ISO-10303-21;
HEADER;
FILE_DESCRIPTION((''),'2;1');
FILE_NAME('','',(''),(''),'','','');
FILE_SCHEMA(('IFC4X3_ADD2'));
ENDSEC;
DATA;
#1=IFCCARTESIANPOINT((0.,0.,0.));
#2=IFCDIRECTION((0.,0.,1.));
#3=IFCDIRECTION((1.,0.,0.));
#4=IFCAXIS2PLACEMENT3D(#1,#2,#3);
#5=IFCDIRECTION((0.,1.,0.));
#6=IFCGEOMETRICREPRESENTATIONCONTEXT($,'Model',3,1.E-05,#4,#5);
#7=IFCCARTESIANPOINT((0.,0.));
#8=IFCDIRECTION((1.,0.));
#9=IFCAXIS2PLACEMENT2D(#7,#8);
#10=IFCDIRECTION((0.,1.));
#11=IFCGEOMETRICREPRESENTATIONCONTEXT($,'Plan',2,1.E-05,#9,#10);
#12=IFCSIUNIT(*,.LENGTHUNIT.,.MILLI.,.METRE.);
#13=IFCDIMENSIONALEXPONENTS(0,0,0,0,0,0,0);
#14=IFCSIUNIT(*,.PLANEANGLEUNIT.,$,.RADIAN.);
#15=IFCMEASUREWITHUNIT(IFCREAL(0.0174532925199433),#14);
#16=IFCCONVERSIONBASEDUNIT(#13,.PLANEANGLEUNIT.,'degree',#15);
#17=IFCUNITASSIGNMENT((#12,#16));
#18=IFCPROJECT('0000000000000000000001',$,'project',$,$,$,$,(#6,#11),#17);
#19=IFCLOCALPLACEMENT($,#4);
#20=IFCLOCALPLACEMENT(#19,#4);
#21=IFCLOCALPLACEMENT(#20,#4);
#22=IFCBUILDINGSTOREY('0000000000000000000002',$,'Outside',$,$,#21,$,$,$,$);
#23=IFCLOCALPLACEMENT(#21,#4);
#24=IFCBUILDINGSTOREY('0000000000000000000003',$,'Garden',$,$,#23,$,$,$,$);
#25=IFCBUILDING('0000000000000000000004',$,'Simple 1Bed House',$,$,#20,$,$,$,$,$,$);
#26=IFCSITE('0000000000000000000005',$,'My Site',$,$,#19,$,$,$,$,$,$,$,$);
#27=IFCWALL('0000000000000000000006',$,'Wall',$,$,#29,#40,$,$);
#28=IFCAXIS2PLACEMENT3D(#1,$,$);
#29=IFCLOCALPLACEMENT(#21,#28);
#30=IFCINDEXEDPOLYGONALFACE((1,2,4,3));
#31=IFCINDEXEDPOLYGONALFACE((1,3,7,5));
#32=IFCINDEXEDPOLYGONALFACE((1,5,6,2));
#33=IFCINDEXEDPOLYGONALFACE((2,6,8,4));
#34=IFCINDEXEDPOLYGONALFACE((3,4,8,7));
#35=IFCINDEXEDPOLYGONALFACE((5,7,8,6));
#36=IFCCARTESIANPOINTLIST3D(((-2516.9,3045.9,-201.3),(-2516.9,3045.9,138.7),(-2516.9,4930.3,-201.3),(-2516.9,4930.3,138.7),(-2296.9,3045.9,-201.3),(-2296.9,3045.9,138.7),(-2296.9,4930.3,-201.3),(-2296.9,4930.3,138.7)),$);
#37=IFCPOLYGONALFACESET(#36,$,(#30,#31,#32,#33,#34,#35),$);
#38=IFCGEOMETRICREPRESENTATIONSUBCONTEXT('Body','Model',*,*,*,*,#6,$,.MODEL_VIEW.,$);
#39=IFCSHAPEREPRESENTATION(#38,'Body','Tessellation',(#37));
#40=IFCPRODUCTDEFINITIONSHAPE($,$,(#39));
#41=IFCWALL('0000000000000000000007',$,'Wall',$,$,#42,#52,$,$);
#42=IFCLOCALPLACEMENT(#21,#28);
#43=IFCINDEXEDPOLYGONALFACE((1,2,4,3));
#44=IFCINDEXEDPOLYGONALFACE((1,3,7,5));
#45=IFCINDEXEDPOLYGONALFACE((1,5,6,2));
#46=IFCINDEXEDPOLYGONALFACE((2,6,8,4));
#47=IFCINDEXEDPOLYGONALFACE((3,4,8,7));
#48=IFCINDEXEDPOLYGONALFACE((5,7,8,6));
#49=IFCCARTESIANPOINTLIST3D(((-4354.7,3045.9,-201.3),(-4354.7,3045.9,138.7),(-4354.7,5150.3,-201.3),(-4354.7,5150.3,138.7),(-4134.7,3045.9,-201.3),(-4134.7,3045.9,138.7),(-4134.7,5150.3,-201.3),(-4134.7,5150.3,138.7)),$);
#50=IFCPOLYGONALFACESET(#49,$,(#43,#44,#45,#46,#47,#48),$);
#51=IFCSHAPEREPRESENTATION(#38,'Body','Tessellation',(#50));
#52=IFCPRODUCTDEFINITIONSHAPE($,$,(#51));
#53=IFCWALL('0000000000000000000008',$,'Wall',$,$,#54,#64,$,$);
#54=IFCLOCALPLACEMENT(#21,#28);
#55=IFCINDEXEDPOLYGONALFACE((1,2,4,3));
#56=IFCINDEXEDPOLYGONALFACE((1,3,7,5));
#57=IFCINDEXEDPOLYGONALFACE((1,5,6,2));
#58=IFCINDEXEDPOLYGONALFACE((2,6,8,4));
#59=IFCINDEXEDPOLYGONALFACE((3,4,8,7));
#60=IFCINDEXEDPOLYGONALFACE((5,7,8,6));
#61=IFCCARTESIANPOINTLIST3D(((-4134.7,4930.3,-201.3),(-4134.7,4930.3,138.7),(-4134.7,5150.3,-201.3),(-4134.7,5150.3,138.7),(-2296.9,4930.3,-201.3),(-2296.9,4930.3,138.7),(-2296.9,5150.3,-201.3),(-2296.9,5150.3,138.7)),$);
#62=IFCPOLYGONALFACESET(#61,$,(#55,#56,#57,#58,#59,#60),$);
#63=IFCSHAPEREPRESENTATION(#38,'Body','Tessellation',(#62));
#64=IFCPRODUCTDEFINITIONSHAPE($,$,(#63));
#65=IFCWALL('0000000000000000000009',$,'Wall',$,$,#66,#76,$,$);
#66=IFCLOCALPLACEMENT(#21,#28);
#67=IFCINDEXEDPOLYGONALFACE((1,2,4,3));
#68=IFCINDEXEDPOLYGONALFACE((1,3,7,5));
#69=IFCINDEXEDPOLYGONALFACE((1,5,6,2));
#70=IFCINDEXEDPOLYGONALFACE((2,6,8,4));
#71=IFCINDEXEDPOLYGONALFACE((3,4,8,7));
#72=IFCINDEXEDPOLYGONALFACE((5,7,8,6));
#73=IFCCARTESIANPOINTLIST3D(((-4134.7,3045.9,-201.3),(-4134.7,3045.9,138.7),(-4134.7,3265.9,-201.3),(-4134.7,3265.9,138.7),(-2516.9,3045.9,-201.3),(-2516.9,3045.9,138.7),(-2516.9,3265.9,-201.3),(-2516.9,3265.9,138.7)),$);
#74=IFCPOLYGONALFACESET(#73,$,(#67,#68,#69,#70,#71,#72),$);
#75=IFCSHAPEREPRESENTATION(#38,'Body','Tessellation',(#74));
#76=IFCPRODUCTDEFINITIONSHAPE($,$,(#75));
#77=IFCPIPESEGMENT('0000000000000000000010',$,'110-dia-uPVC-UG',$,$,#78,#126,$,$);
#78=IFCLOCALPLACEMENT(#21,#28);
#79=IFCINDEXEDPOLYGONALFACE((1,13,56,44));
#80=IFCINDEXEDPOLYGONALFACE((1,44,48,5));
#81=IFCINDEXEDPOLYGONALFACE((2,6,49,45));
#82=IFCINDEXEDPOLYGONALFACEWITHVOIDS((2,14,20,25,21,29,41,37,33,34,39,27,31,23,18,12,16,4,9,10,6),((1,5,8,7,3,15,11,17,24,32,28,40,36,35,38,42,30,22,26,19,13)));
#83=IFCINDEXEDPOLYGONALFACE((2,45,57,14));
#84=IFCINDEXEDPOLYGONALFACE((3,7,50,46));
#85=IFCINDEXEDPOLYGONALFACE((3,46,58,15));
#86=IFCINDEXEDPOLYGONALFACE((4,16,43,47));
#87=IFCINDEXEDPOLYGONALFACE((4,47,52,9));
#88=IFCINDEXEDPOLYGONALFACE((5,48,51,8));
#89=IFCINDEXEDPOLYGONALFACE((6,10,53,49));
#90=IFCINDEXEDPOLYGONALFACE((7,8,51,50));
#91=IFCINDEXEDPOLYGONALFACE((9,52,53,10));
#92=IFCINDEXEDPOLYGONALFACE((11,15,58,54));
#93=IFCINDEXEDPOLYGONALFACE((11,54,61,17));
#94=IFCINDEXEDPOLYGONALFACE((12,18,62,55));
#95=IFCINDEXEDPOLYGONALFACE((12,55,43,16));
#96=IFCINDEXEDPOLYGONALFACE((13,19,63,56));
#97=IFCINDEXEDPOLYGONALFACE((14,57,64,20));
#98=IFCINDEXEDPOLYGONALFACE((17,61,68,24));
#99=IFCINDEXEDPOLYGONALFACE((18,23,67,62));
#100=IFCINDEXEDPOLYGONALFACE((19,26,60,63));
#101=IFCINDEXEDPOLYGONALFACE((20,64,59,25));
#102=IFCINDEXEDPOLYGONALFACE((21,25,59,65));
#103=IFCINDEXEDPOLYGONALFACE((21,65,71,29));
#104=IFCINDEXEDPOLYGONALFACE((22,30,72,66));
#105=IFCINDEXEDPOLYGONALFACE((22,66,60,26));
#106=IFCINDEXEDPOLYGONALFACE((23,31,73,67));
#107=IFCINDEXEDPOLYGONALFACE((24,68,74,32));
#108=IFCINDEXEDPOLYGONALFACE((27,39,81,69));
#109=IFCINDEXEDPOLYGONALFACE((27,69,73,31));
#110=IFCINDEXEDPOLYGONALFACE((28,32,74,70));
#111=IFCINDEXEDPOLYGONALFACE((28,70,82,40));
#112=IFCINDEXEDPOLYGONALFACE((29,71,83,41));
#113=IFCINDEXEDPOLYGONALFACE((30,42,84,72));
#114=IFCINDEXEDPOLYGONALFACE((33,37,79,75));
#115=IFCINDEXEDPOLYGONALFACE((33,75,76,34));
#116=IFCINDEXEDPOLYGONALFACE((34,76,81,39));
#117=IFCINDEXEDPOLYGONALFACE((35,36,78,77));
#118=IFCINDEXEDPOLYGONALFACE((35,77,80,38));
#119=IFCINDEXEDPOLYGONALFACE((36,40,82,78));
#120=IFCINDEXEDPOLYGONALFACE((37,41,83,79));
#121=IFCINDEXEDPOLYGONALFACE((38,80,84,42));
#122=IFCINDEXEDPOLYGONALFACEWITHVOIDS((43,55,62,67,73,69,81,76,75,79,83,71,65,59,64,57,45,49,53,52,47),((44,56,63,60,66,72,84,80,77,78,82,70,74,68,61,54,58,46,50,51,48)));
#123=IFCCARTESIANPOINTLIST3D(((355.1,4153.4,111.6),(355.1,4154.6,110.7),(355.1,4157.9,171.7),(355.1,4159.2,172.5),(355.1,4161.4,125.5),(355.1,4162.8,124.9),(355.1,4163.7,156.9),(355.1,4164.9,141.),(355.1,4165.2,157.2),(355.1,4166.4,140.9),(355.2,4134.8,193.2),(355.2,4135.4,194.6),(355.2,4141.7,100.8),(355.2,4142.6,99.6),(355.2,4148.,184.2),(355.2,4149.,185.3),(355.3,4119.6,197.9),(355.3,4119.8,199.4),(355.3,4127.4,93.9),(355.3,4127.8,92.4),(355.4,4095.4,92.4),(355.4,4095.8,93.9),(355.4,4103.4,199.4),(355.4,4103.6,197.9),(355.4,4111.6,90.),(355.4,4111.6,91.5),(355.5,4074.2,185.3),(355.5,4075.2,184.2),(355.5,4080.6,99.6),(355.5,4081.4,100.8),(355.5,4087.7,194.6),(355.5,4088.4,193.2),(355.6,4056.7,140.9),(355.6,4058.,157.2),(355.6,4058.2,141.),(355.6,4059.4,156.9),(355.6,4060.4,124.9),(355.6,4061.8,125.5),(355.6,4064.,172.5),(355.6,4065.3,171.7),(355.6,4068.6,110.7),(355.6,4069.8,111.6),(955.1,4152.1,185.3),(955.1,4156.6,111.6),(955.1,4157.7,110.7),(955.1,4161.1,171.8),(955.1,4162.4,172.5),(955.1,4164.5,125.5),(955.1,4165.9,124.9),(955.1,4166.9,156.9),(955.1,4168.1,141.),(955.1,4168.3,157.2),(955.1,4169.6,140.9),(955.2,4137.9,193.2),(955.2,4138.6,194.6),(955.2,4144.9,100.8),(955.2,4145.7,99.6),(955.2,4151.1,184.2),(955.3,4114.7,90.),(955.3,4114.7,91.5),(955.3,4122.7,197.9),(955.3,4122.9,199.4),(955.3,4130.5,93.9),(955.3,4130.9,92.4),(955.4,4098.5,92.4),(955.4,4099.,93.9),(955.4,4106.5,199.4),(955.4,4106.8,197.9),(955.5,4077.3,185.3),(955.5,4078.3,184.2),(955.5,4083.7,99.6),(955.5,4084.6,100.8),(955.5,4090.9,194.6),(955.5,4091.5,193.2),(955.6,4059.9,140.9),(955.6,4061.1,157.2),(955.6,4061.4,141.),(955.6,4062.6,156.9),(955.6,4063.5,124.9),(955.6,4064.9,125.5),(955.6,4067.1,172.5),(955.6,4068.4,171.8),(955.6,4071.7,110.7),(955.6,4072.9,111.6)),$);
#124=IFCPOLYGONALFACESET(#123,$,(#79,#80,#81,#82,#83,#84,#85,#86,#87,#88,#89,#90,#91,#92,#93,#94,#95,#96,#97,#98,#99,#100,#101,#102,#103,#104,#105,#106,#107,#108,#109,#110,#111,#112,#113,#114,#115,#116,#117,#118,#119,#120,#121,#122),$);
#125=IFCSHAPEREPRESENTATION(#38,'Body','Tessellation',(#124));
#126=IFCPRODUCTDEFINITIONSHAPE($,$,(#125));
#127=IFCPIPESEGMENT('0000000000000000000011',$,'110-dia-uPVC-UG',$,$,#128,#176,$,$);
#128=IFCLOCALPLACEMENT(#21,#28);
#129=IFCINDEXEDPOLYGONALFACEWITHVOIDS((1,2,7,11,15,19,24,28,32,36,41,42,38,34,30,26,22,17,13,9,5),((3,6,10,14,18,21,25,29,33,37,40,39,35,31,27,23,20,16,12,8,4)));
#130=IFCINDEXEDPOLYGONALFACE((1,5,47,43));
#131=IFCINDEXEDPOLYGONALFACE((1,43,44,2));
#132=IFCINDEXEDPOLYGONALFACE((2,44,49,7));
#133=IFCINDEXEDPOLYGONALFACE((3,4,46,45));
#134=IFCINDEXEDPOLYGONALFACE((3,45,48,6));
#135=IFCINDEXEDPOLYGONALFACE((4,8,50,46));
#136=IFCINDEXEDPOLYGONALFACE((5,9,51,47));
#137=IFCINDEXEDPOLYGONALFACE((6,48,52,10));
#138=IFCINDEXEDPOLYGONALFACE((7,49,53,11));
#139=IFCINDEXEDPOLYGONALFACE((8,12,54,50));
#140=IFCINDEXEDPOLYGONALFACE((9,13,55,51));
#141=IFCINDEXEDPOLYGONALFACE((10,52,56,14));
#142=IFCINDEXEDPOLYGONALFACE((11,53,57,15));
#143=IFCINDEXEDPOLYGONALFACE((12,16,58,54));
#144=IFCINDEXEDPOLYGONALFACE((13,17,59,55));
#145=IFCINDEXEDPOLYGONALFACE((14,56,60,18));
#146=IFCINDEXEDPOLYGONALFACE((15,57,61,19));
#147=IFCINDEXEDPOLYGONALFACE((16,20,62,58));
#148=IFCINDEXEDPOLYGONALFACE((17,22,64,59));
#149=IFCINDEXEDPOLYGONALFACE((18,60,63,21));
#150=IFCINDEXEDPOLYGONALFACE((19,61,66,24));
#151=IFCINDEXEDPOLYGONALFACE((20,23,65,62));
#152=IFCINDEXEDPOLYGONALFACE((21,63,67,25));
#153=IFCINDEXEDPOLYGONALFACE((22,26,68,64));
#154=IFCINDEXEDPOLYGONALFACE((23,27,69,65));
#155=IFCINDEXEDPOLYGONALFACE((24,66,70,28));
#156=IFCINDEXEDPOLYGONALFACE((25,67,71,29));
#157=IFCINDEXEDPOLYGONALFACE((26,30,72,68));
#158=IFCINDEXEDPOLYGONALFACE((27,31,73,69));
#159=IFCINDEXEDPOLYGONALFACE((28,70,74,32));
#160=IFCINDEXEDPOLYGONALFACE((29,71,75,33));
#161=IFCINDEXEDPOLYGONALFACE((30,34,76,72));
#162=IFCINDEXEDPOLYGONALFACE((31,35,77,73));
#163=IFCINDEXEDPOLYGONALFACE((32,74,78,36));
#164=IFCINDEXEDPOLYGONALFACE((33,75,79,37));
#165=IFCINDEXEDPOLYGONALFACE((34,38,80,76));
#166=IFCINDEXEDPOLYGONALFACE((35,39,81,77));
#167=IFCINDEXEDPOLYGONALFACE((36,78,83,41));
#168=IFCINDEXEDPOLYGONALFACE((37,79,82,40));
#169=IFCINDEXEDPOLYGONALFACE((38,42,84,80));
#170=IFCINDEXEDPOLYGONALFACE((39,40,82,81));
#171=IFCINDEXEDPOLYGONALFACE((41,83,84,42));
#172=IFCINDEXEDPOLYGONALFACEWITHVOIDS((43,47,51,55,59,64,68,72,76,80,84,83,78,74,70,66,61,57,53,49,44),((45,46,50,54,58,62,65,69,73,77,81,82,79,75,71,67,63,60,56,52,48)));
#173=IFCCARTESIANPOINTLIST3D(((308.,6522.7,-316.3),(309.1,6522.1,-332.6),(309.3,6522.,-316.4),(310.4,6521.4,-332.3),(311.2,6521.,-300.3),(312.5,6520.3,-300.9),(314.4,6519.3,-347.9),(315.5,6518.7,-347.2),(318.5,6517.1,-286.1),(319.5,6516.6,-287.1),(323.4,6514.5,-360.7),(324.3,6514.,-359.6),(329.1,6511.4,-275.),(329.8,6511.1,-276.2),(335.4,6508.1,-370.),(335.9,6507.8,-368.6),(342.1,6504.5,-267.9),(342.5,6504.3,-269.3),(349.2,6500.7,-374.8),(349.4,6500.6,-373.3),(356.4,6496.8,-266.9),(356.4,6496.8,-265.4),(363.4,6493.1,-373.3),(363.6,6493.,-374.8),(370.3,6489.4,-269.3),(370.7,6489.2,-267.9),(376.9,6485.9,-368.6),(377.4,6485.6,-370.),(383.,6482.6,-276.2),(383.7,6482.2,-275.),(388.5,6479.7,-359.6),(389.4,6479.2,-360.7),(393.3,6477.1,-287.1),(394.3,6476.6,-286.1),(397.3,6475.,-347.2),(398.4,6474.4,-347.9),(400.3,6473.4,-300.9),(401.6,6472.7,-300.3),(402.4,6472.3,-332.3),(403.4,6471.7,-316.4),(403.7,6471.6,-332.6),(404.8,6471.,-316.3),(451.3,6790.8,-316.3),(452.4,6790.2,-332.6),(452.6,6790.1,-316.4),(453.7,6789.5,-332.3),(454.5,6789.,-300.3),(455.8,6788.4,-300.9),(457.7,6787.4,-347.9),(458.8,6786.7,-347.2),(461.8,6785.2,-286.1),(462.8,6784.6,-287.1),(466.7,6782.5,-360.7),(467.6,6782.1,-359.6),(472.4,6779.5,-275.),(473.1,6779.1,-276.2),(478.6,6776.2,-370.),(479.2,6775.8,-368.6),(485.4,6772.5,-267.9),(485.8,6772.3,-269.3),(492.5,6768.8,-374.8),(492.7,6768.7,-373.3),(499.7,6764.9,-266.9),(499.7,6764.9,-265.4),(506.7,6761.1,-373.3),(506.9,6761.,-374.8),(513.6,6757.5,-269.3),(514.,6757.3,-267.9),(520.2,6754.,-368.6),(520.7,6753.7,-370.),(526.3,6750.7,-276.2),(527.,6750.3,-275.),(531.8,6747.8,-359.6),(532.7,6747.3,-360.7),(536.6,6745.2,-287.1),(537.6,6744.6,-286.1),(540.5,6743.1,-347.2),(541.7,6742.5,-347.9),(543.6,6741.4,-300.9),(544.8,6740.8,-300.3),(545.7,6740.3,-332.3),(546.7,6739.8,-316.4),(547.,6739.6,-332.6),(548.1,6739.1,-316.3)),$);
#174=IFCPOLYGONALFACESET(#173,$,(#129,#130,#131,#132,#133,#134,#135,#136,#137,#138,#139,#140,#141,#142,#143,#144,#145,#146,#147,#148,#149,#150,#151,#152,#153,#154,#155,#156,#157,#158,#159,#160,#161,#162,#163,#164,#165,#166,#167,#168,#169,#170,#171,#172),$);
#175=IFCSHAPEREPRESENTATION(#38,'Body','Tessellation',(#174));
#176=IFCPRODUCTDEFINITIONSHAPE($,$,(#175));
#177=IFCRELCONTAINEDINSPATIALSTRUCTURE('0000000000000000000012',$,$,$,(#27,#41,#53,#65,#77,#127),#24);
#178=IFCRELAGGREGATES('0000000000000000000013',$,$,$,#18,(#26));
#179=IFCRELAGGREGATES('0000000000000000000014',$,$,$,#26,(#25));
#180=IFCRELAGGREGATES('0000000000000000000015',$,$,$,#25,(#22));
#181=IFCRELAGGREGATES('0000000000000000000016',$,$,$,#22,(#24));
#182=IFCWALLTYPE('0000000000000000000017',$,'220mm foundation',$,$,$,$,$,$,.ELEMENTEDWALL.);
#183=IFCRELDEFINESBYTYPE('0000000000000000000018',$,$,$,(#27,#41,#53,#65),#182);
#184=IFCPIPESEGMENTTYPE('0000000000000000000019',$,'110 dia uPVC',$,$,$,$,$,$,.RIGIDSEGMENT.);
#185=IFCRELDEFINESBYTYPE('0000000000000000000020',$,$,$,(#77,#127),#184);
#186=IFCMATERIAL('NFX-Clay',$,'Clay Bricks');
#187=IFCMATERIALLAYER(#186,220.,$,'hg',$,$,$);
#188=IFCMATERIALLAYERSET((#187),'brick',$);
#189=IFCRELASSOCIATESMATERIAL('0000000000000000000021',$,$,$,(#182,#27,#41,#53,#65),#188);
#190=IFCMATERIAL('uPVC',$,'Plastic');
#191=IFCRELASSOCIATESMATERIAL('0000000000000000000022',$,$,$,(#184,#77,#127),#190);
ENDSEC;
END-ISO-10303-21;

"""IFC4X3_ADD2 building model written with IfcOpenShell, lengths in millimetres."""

from ifc_helpers import new_model, entity, si_unit, converted_unit, direction, frame, origin_with_axes, origin_2d_with_axis, place, context, subcontext, project, spatial, indexed_curve, hollow_circle, outline, extrude, material, layer, layer_set, layer_usage, material_profile, profile_set, profile_usage, type_object, element, save


model = new_model("IFC4X3_ADD2")

# Units and contexts
model_context = context("Model", 3, precision=1e-05, world=origin_with_axes(), true_north=direction((0.0, 1.0, 0.0)))
plan_context = context("Plan", 2, precision=1e-05, world=origin_2d_with_axis(), true_north=direction((0.0, 1.0)))
body_context = subcontext(model_context, "Body", "Model", "MODEL_VIEW")
ifc_project = project(units=[si_unit("LENGTHUNIT", "METRE", prefix="MILLI"), converted_unit("PLANEANGLEUNIT", "degree", entity("IfcReal", 0.0174532925199433), si_unit("PLANEANGLEUNIT", "RADIAN"), dimensions=[0, 0, 0, 0, 0, 0, 0])], contexts=[model_context, plan_context])

# Site, building, storeys
site_placement = place(None, origin_with_axes())
site = spatial("IfcSite", under=ifc_project, at=site_placement, Name="My Site")
building_placement = place(site_placement, origin_with_axes())
building = spatial("IfcBuilding", under=site, at=building_placement, Name="Simple 1Bed House")
storey_1_placement = place(building_placement, origin_with_axes())
storey_1 = spatial("IfcBuildingStorey", under=building, at=storey_1_placement, Name="Outside")
storey_2_placement = place(storey_1_placement, origin_with_axes())
storey_2 = spatial("IfcBuildingStorey", under=storey_1, at=storey_2_placement, Name="Garden")

# Walls
ifc_material_1 = material(Name="NFX-Clay", Category="Clay Bricks")
ifc_layer_1 = layer(ifc_material_1, 220.0, Name="hg")
ifc_layer_set_1 = layer_set([ifc_layer_1], Name="brick")
ifc_layer_usage_1 = layer_usage(ifc_layer_set_1, "AXIS2", "POSITIVE", 0.0)
wall_type = type_object("IfcWallType", Name="220mm foundation", PredefinedType="ELEMENTEDWALL", material=ifc_layer_set_1)
wall_1_placement = place(storey_2_placement, frame((-2296.9, 3045.9, -201.3), z_axis=(0.0, 0.0, 1.0), x_axis=(0.0, 1.0, 0.0)))
element("IfcWall", 1, at=wall_1_placement, inside=storey_2, type_object=wall_type, material=ifc_layer_usage_1, Name="Wall", context=body_context, shape_type="SweptSolid", body=[
    extrude(outline(indexed_curve([(0.0, 0.0), (0.0, 220.0), (1884.4, 220.0), (1884.4, 0.0), (0.0, 0.0)], self_intersect=False)), origin_with_axes(), (0.0, 0.0, 1.0), 340.0),
])
ifc_layer_usage_2 = layer_usage(ifc_layer_set_1, "AXIS2", "POSITIVE", 0.0)
wall_2_placement = place(storey_2_placement, frame((-4354.7, 5150.3, -201.3), z_axis=(0.0, 0.0, 1.0), x_axis=(0.0, -1.0, 0.0)))
element("IfcWall", 2, at=wall_2_placement, inside=storey_2, type_object=wall_type, material=ifc_layer_usage_2, Name="Wall", context=body_context, shape_type="SweptSolid", body=[
    extrude(outline(indexed_curve([(0.0, 0.0), (0.0, 220.0), (2104.4, 220.0), (2104.4, 0.0), (0.0, 0.0)], self_intersect=False)), origin_with_axes(), (0.0, 0.0, 1.0), 340.0),
])
ifc_layer_usage_3 = layer_usage(ifc_layer_set_1, "AXIS2", "POSITIVE", 0.0)
wall_3_placement = place(storey_2_placement, frame((-2296.9, 5150.3, -201.3), z_axis=(0.0, 0.0, 1.0), x_axis=(-1.0, 0.0, 0.0)))
element("IfcWall", 3, at=wall_3_placement, inside=storey_2, type_object=wall_type, material=ifc_layer_usage_3, Name="Wall", context=body_context, shape_type="SweptSolid", body=[
    extrude(outline(indexed_curve([(0.0, 0.0), (0.0, 220.0), (1837.8, 220.0), (1837.8, 0.0), (0.0, 0.0)], self_intersect=False)), origin_with_axes(), (0.0, 0.0, 1.0), 340.0),
])
ifc_layer_usage_4 = layer_usage(ifc_layer_set_1, "AXIS2", "POSITIVE", 0.0)
wall_4_placement = place(storey_2_placement, frame((-4134.7, 3045.9, -201.3), z_axis=(0.0, 0.0, 1.0), x_axis=(1.0, 0.0, 0.0)))
element("IfcWall", 4, at=wall_4_placement, inside=storey_2, type_object=wall_type, material=ifc_layer_usage_4, Name="Wall", context=body_context, shape_type="SweptSolid", body=[
    extrude(outline(indexed_curve([(0.0, 0.0), (0.0, 220.0), (1617.8, 220.0), (1617.8, 0.0), (0.0, 0.0)], self_intersect=False)), origin_with_axes(), (0.0, 0.0, 1.0), 340.0),
])

# Pipe segments
ifc_material_2 = material(Name="uPVC", Category="Plastic")
ifc_material_profile = material_profile(ifc_material_2, hollow_circle(Radius=55.0, WallThickness=1.5))
ifc_profile_set = profile_set([ifc_material_profile])
pipe_segment_type = type_object("IfcPipeSegmentType", Name="110 dia uPVC", PredefinedType="RIGIDSEGMENT", material=ifc_profile_set)
ifc_profile_usage_1 = profile_usage(ifc_profile_set, cardinal=5)
pipe_segment_1_placement = place(storey_2_placement, frame((355.4, 4111.6, 145.0), z_axis=(0.999986, 0.005237, 0.0), x_axis=(0.0, 0.0, -1.0)))
element("IfcPipeSegment", 5, at=pipe_segment_1_placement, inside=storey_2, type_object=pipe_segment_type, material=ifc_profile_usage_1, Name="110-dia-uPVC-UG", context=body_context, shape_type="SweptSolid", body=[
    extrude(hollow_circle(Radius=55.0, WallThickness=1.5), origin_with_axes(), (0.0, 0.0, 1.0), 600.0),
])
ifc_profile_usage_2 = profile_usage(ifc_profile_set, cardinal=5)
pipe_segment_2_placement = place(storey_2_placement, frame((499.7, 6764.9, -320.4), z_axis=(-0.471415, -0.881911, 0.0), x_axis=(0.0, 0.0, 1.0)))
element("IfcPipeSegment", 6, at=pipe_segment_2_placement, inside=storey_2, type_object=pipe_segment_type, material=ifc_profile_usage_2, Name="110-dia-uPVC-UG", context=body_context, shape_type="SweptSolid", body=[
    extrude(hollow_circle(Radius=55.0, WallThickness=1.5), origin_with_axes(), (0.0, 0.0, 1.0), 304.0),
])

save(model, "model.ifc")
